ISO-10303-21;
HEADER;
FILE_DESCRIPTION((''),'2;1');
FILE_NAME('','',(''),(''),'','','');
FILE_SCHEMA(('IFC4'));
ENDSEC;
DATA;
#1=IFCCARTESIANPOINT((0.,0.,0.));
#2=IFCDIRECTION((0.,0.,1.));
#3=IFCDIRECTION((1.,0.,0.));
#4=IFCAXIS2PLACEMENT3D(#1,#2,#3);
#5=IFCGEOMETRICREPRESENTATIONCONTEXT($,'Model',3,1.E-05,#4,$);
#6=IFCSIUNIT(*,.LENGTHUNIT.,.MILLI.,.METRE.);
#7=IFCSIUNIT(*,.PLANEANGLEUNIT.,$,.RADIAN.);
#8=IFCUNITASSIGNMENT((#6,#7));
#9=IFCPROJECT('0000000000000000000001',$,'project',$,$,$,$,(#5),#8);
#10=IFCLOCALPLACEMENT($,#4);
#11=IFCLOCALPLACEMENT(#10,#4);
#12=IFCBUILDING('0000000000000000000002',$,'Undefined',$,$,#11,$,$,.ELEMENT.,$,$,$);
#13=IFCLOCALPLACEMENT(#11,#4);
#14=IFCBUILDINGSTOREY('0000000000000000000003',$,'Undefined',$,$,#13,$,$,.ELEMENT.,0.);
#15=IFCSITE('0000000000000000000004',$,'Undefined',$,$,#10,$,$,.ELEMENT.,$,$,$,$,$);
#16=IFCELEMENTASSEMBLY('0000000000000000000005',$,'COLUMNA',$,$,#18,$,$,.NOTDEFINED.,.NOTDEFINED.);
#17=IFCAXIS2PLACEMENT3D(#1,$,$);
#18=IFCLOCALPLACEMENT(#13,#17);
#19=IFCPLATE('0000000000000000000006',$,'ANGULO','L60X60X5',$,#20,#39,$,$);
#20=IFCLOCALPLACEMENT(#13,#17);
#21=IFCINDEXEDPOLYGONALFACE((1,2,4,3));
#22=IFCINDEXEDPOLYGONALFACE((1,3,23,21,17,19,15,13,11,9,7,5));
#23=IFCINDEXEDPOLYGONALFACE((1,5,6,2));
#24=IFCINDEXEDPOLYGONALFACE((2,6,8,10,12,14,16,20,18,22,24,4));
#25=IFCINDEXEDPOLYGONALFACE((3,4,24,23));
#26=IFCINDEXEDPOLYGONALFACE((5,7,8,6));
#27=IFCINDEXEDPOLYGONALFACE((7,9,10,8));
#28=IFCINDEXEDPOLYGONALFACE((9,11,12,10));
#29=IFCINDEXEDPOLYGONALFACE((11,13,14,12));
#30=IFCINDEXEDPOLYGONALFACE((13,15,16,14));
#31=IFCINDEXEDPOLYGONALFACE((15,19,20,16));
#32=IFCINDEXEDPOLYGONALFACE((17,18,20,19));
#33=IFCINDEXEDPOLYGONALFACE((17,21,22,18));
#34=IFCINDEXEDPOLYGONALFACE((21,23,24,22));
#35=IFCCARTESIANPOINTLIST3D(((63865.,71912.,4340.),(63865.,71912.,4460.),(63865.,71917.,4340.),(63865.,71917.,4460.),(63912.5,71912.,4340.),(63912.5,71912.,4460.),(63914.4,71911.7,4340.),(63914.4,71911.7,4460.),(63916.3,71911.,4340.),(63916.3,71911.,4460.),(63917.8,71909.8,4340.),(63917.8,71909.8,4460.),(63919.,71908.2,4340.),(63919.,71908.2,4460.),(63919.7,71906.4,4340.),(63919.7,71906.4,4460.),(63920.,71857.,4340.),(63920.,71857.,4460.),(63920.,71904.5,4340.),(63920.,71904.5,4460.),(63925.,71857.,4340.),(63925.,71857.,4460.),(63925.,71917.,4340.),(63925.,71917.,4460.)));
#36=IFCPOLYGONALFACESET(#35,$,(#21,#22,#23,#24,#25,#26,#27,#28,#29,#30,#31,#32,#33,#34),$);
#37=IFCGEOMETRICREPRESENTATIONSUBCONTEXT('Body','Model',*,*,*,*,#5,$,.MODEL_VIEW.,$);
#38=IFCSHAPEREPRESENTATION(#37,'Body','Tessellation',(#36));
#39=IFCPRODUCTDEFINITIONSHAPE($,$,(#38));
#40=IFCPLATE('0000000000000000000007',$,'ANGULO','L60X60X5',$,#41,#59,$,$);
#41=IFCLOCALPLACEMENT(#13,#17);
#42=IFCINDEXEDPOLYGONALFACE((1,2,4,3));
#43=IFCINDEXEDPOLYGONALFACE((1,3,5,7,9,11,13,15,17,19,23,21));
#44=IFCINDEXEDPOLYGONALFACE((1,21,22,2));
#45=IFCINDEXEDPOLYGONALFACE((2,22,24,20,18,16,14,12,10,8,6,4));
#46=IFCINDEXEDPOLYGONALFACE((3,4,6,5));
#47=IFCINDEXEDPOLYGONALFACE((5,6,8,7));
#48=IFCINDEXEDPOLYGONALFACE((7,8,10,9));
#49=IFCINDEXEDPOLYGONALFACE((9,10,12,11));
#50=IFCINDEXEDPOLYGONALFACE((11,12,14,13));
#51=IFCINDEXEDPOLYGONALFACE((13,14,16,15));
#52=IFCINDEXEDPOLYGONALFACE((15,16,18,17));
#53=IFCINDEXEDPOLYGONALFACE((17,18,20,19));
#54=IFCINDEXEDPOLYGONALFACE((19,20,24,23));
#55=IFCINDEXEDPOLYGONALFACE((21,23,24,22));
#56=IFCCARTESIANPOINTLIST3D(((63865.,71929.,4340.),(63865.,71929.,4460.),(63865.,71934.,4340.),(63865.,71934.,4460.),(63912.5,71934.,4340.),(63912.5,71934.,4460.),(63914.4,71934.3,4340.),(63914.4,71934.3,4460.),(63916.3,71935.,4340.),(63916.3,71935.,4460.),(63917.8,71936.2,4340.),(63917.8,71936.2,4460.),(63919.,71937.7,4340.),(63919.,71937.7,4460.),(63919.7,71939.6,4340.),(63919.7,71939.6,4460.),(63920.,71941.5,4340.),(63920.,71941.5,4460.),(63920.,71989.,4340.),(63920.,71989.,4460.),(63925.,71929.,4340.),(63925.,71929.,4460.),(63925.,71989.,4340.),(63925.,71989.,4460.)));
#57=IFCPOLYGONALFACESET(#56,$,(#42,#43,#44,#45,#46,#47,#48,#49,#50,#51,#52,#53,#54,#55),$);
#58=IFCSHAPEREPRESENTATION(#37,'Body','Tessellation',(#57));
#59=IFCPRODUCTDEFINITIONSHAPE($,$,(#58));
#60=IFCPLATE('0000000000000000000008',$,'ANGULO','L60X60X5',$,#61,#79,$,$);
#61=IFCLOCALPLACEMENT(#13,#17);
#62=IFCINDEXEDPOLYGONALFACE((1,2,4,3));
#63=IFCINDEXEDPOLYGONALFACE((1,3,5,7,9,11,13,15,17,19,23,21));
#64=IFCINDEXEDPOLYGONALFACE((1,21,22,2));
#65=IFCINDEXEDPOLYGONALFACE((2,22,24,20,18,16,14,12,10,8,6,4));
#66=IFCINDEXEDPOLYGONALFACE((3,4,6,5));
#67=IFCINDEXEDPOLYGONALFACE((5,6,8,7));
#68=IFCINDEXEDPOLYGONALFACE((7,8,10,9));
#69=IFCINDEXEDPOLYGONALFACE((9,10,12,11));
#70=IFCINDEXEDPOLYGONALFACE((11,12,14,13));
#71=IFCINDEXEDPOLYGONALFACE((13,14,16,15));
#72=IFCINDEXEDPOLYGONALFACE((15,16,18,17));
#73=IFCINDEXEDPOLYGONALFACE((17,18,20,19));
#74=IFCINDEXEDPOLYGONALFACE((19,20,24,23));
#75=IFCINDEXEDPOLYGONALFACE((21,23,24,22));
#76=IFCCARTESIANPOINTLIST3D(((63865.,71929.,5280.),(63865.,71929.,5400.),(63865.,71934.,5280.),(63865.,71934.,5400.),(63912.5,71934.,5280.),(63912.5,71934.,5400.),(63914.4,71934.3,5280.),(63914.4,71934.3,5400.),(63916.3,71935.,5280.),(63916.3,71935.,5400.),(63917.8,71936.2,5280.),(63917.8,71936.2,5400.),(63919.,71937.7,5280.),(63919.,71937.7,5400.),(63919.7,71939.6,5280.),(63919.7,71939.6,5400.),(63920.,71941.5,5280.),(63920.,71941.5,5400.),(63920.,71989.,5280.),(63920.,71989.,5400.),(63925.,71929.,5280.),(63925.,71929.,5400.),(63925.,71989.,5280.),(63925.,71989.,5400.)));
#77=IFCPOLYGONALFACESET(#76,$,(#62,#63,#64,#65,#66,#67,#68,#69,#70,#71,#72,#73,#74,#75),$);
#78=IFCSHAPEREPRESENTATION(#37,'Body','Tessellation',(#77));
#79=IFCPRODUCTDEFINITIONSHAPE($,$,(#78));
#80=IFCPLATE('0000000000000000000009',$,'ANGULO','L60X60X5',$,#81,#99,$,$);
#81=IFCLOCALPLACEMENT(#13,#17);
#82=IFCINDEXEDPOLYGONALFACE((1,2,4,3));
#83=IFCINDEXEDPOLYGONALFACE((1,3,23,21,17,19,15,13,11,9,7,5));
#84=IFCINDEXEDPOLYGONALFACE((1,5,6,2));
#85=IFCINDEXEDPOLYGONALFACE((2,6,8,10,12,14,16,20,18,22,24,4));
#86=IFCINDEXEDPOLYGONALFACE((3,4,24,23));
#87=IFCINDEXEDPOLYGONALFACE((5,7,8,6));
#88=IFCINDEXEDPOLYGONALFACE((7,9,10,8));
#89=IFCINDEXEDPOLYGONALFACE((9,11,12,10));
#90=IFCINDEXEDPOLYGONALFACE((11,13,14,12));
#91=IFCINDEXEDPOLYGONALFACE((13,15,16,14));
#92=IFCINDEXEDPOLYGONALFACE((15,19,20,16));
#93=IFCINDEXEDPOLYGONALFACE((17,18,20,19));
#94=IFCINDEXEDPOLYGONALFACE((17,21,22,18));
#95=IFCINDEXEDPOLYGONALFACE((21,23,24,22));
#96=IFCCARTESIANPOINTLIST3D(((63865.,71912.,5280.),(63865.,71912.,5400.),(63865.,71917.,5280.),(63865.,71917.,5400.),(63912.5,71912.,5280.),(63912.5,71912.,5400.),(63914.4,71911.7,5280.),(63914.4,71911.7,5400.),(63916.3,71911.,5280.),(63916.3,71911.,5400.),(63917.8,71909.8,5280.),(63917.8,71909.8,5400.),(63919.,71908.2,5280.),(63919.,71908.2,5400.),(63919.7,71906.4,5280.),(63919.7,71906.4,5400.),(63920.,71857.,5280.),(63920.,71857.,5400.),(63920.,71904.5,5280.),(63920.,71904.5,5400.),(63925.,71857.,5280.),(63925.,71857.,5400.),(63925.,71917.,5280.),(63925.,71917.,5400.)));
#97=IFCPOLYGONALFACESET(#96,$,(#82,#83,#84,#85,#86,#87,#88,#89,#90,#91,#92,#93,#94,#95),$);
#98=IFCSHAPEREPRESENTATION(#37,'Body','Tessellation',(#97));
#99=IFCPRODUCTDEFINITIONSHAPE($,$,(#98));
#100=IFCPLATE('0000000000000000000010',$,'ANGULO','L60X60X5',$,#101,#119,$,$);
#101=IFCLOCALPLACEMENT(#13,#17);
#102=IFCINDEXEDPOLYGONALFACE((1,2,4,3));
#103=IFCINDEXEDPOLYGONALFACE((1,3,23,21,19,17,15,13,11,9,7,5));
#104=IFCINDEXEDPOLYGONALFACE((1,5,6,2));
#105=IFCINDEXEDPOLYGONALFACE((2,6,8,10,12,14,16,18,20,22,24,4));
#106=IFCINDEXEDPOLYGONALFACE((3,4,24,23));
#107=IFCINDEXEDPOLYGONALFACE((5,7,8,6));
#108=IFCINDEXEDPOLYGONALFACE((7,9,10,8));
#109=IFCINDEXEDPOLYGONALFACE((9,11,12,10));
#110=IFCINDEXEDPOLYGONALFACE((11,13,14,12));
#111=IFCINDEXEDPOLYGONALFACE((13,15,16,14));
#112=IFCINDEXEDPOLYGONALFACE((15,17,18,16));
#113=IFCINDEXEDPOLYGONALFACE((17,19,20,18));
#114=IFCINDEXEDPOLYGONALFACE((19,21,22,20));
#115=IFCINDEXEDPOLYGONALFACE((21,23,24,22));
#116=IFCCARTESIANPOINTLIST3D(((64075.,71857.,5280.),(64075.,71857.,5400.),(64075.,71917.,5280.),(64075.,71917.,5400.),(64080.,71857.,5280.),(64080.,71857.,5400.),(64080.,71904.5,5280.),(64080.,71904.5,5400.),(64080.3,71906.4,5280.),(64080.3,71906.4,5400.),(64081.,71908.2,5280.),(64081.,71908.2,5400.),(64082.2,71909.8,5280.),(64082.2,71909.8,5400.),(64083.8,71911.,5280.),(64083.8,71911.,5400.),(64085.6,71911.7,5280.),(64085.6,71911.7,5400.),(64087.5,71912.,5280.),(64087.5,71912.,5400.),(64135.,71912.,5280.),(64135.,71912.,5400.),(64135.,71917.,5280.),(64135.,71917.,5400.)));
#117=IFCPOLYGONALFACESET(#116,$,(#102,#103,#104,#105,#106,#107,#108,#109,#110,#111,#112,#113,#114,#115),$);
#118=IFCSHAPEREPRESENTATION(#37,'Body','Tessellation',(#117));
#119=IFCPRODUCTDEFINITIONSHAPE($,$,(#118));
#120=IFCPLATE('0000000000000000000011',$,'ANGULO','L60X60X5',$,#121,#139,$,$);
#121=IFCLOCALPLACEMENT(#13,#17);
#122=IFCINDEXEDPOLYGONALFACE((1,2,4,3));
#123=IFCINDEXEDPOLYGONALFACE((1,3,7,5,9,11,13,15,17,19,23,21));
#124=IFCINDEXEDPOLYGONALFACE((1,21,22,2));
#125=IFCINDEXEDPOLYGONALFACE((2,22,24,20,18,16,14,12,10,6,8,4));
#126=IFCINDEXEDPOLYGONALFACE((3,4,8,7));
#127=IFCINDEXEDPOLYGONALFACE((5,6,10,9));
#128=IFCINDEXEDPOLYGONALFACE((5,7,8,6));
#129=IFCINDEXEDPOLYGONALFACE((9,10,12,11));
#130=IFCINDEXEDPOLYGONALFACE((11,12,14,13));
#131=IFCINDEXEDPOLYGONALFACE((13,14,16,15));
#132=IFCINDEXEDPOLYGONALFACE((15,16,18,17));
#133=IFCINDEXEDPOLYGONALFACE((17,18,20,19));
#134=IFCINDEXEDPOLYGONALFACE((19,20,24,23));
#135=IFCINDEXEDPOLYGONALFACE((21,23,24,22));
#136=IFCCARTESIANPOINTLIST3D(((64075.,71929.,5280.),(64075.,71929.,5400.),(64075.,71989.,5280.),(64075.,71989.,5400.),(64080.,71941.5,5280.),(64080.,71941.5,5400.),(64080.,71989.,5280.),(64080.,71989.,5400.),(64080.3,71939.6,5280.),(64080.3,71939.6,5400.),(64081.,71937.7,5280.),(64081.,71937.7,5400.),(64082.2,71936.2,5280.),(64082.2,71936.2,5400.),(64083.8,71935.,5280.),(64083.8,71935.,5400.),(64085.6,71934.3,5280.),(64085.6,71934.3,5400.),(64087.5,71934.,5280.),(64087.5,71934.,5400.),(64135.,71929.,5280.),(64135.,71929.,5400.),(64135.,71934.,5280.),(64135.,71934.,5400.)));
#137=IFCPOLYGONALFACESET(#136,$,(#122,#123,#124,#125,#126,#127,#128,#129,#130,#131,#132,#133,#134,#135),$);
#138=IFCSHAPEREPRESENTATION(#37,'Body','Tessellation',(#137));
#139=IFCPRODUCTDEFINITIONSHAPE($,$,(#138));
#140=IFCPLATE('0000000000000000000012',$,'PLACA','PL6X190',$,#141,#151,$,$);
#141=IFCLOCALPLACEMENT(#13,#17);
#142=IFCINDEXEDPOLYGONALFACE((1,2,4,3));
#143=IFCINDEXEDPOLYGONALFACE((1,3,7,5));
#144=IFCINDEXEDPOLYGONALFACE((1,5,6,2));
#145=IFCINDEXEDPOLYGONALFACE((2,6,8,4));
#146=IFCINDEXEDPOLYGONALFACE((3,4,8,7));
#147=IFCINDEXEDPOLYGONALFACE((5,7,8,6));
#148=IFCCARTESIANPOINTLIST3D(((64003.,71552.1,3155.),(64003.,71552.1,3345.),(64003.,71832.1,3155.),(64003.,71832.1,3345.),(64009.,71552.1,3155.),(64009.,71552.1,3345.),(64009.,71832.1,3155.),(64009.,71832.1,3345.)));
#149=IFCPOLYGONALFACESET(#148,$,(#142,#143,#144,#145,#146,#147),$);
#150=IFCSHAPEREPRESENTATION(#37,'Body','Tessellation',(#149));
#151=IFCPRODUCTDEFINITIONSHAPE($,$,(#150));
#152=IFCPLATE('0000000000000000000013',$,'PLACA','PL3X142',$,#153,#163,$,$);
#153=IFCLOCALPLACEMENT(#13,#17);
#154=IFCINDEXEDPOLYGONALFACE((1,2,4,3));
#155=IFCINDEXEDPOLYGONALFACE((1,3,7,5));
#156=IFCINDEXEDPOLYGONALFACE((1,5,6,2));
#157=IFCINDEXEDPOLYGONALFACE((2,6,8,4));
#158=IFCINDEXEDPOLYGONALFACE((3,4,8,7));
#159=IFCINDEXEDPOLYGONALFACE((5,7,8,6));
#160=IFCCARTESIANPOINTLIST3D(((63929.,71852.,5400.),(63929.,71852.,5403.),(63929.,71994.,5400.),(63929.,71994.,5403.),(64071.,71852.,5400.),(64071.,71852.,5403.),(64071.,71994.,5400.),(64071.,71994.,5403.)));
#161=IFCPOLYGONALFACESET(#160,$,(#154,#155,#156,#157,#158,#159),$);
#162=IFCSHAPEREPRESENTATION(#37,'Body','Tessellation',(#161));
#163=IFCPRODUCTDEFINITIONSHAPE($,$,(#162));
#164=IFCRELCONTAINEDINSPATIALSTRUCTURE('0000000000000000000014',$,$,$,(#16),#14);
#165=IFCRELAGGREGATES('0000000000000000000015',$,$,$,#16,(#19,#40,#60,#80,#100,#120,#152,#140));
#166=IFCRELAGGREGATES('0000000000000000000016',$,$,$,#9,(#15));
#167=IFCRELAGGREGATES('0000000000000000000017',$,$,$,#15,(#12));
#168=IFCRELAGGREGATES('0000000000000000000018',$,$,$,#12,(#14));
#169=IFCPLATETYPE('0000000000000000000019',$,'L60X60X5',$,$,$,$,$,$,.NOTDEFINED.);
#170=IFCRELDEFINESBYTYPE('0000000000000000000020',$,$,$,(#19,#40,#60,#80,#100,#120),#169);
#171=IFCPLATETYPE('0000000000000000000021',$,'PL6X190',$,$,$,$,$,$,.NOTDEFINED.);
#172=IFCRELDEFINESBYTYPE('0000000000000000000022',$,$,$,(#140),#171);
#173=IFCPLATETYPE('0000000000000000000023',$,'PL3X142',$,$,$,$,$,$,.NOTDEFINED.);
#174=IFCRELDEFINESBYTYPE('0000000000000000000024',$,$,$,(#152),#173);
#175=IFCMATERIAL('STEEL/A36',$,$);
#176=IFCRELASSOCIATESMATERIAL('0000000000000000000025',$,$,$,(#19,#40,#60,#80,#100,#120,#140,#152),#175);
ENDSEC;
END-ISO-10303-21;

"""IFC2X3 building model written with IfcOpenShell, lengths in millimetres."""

from ifc_helpers import new_model, si_unit, frame, origin_with_axes, origin_2d_with_axis, place, context, subcontext, project, spatial, polyline, l_section, outline, extrude, material, type_object, element, aggregate, save


model = new_model("IFC2X3")

# Units and contexts
model_context = context("Model", 3, precision=1e-05, world=origin_with_axes())
body_context = subcontext(model_context, "Body", "Model", "MODEL_VIEW")
ifc_project = project(units=[si_unit("LENGTHUNIT", "METRE", prefix="MILLI"), si_unit("PLANEANGLEUNIT", "RADIAN")], contexts=[model_context])

# Site, building, storey
site_placement = place(None, origin_with_axes())
site = spatial("IfcSite", under=ifc_project, at=site_placement, Name="Undefined", CompositionType="ELEMENT")
building_placement = place(site_placement, origin_with_axes())
building = spatial("IfcBuilding", under=site, at=building_placement, Name="Undefined", CompositionType="ELEMENT")
storey_placement = place(building_placement, origin_with_axes())
storey = spatial("IfcBuildingStorey", under=building, at=storey_placement, Name="Undefined", CompositionType="ELEMENT", Elevation=0.0)

# Element assembly
assembly_1_placement = place(storey_placement, origin_with_axes())
assembly_1 = element("IfcElementAssembly", 1, at=assembly_1_placement, inside=storey, Name="COLUMNA", AssemblyPlace="NOTDEFINED", PredefinedType="NOTDEFINED")
ifc_material_1 = material(Name="STEEL/A36")

# Plates
plate_type_1 = type_object("IfcPlateType", Name="L60X60X5", PredefinedType="NOTDEFINED")
plate_1_placement = place(assembly_1_placement, frame((63895.0, 71887.0, 4460.0), z_axis=(0.0, -1.0, 0.0), x_axis=(0.0, 0.0, -1.0)))
plate_1 = element("IfcPlate", 2, at=plate_1_placement, type_object=plate_type_1, material=ifc_material_1, Name="ANGULO", Description="L60X60X5", context=body_context, shape_type="SweptSolid", body=[
    extrude(l_section(Depth=60.0, Width=60.0, Thickness=5.0, FilletRadius=7.5, at=origin_2d_with_axis()), frame((120.0, 0.0, 0.0), z_axis=(-1.0, 0.0, 0.0), x_axis=(0.0, -1.0, 0.0)), (0.0, 0.0, 1.0), 120.0),
])
plate_2_placement = place(assembly_1_placement, frame((63895.0, 71959.0, 4340.0), z_axis=(0.0, 1.0, 0.0), x_axis=(0.0, 0.0, 1.0)))
plate_2 = element("IfcPlate", 3, at=plate_2_placement, type_object=plate_type_1, material=ifc_material_1, Name="ANGULO", Description="L60X60X5", context=body_context, shape_type="SweptSolid", body=[
    extrude(l_section(Depth=60.0, Width=60.0, Thickness=5.0, FilletRadius=7.5, at=origin_2d_with_axis()), frame((120.0, 0.0, 0.0), z_axis=(-1.0, 0.0, 0.0), x_axis=(0.0, -1.0, 0.0)), (0.0, 0.0, 1.0), 120.0),
])
plate_3_placement = place(assembly_1_placement, frame((63895.0, 71959.0, 5280.0), z_axis=(0.0, 1.0, 0.0), x_axis=(0.0, 0.0, 1.0)))
plate_3 = element("IfcPlate", 4, at=plate_3_placement, type_object=plate_type_1, material=ifc_material_1, Name="ANGULO", Description="L60X60X5", context=body_context, shape_type="SweptSolid", body=[
    extrude(l_section(Depth=60.0, Width=60.0, Thickness=5.0, FilletRadius=7.5, at=origin_2d_with_axis()), frame((120.0, 0.0, 0.0), z_axis=(-1.0, 0.0, 0.0), x_axis=(0.0, -1.0, 0.0)), (0.0, 0.0, 1.0), 120.0),
])
plate_4_placement = place(assembly_1_placement, frame((63895.0, 71887.0, 5400.0), z_axis=(0.0, -1.0, 0.0), x_axis=(0.0, 0.0, -1.0)))
plate_4 = element("IfcPlate", 5, at=plate_4_placement, type_object=plate_type_1, material=ifc_material_1, Name="ANGULO", Description="L60X60X5", context=body_context, shape_type="SweptSolid", body=[
    extrude(l_section(Depth=60.0, Width=60.0, Thickness=5.0, FilletRadius=7.5, at=origin_2d_with_axis()), frame((120.0, 0.0, 0.0), z_axis=(-1.0, 0.0, 0.0), x_axis=(0.0, -1.0, 0.0)), (0.0, 0.0, 1.0), 120.0),
])
plate_5_placement = place(assembly_1_placement, frame((64105.0, 71887.0, 5280.0), z_axis=(0.0, -1.0, 0.0), x_axis=(0.0, 0.0, 1.0)))
plate_5 = element("IfcPlate", 6, at=plate_5_placement, type_object=plate_type_1, material=ifc_material_1, Name="ANGULO", Description="L60X60X5", context=body_context, shape_type="SweptSolid", body=[
    extrude(l_section(Depth=60.0, Width=60.0, Thickness=5.0, FilletRadius=7.5, at=origin_2d_with_axis()), frame((120.0, 0.0, 0.0), z_axis=(-1.0, 0.0, 0.0), x_axis=(0.0, -1.0, 0.0)), (0.0, 0.0, 1.0), 120.0),
])
plate_6_placement = place(assembly_1_placement, frame((64105.0, 71959.0, 5400.0), z_axis=(0.0, 1.0, 0.0), x_axis=(0.0, 0.0, -1.0)))
plate_6 = element("IfcPlate", 7, at=plate_6_placement, type_object=plate_type_1, material=ifc_material_1, Name="ANGULO", Description="L60X60X5", context=body_context, shape_type="SweptSolid", body=[
    extrude(l_section(Depth=60.0, Width=60.0, Thickness=5.0, FilletRadius=7.5, at=origin_2d_with_axis()), frame((120.0, 0.0, 0.0), z_axis=(-1.0, 0.0, 0.0), x_axis=(0.0, -1.0, 0.0)), (0.0, 0.0, 1.0), 120.0),
])
plate_type_2 = type_object("IfcPlateType", Name="PL6X190", PredefinedType="NOTDEFINED")
plate_7_placement = place(assembly_1_placement, frame((64006.0, 71552.1, 3250.0), z_axis=(1.0, 0.0, 0.0), x_axis=(0.0, 1.0, 0.0)))
plate_7 = element("IfcPlate", 8, at=plate_7_placement, type_object=plate_type_2, material=ifc_material_1, Name="PLACA", Description="PL6X190", context=body_context, shape_type="SweptSolid", body=[
    extrude(outline(polyline([(0.0, -95.0), (0.0, 95.0), (280.0, 95.0), (280.0, -95.0), (0.0, -95.0)])), frame((0.0, 0.0, -3.0), z_axis=(0.0, 0.0, 1.0), x_axis=(1.0, 0.0, 0.0)), (0.0, 0.0, 1.0), 6.0),
])
plate_type_3 = type_object("IfcPlateType", Name="PL3X142", PredefinedType="NOTDEFINED")
plate_8_placement = place(assembly_1_placement, frame((64071.0, 71994.0, 5401.5), z_axis=(0.0, 0.0, -1.0), x_axis=(0.0, -1.0, 0.0)))
plate_8 = element("IfcPlate", 9, at=plate_8_placement, type_object=plate_type_3, material=ifc_material_1, Name="PLACA", Description="PL3X142", context=body_context, shape_type="SweptSolid", body=[
    extrude(outline(polyline([(0.0, 0.0), (142.0, 0.0), (142.0, 142.0), (0.0, 142.0), (0.0, 0.0)])), frame((0.0, 0.0, -1.5), z_axis=(0.0, 0.0, 1.0), x_axis=(1.0, 0.0, 0.0)), (0.0, 0.0, 1.0), 3.0),
])

aggregate(assembly_1, [plate_1, plate_2, plate_3, plate_4, plate_5, plate_6, plate_8, plate_7])

save(model, "model.ifc")
